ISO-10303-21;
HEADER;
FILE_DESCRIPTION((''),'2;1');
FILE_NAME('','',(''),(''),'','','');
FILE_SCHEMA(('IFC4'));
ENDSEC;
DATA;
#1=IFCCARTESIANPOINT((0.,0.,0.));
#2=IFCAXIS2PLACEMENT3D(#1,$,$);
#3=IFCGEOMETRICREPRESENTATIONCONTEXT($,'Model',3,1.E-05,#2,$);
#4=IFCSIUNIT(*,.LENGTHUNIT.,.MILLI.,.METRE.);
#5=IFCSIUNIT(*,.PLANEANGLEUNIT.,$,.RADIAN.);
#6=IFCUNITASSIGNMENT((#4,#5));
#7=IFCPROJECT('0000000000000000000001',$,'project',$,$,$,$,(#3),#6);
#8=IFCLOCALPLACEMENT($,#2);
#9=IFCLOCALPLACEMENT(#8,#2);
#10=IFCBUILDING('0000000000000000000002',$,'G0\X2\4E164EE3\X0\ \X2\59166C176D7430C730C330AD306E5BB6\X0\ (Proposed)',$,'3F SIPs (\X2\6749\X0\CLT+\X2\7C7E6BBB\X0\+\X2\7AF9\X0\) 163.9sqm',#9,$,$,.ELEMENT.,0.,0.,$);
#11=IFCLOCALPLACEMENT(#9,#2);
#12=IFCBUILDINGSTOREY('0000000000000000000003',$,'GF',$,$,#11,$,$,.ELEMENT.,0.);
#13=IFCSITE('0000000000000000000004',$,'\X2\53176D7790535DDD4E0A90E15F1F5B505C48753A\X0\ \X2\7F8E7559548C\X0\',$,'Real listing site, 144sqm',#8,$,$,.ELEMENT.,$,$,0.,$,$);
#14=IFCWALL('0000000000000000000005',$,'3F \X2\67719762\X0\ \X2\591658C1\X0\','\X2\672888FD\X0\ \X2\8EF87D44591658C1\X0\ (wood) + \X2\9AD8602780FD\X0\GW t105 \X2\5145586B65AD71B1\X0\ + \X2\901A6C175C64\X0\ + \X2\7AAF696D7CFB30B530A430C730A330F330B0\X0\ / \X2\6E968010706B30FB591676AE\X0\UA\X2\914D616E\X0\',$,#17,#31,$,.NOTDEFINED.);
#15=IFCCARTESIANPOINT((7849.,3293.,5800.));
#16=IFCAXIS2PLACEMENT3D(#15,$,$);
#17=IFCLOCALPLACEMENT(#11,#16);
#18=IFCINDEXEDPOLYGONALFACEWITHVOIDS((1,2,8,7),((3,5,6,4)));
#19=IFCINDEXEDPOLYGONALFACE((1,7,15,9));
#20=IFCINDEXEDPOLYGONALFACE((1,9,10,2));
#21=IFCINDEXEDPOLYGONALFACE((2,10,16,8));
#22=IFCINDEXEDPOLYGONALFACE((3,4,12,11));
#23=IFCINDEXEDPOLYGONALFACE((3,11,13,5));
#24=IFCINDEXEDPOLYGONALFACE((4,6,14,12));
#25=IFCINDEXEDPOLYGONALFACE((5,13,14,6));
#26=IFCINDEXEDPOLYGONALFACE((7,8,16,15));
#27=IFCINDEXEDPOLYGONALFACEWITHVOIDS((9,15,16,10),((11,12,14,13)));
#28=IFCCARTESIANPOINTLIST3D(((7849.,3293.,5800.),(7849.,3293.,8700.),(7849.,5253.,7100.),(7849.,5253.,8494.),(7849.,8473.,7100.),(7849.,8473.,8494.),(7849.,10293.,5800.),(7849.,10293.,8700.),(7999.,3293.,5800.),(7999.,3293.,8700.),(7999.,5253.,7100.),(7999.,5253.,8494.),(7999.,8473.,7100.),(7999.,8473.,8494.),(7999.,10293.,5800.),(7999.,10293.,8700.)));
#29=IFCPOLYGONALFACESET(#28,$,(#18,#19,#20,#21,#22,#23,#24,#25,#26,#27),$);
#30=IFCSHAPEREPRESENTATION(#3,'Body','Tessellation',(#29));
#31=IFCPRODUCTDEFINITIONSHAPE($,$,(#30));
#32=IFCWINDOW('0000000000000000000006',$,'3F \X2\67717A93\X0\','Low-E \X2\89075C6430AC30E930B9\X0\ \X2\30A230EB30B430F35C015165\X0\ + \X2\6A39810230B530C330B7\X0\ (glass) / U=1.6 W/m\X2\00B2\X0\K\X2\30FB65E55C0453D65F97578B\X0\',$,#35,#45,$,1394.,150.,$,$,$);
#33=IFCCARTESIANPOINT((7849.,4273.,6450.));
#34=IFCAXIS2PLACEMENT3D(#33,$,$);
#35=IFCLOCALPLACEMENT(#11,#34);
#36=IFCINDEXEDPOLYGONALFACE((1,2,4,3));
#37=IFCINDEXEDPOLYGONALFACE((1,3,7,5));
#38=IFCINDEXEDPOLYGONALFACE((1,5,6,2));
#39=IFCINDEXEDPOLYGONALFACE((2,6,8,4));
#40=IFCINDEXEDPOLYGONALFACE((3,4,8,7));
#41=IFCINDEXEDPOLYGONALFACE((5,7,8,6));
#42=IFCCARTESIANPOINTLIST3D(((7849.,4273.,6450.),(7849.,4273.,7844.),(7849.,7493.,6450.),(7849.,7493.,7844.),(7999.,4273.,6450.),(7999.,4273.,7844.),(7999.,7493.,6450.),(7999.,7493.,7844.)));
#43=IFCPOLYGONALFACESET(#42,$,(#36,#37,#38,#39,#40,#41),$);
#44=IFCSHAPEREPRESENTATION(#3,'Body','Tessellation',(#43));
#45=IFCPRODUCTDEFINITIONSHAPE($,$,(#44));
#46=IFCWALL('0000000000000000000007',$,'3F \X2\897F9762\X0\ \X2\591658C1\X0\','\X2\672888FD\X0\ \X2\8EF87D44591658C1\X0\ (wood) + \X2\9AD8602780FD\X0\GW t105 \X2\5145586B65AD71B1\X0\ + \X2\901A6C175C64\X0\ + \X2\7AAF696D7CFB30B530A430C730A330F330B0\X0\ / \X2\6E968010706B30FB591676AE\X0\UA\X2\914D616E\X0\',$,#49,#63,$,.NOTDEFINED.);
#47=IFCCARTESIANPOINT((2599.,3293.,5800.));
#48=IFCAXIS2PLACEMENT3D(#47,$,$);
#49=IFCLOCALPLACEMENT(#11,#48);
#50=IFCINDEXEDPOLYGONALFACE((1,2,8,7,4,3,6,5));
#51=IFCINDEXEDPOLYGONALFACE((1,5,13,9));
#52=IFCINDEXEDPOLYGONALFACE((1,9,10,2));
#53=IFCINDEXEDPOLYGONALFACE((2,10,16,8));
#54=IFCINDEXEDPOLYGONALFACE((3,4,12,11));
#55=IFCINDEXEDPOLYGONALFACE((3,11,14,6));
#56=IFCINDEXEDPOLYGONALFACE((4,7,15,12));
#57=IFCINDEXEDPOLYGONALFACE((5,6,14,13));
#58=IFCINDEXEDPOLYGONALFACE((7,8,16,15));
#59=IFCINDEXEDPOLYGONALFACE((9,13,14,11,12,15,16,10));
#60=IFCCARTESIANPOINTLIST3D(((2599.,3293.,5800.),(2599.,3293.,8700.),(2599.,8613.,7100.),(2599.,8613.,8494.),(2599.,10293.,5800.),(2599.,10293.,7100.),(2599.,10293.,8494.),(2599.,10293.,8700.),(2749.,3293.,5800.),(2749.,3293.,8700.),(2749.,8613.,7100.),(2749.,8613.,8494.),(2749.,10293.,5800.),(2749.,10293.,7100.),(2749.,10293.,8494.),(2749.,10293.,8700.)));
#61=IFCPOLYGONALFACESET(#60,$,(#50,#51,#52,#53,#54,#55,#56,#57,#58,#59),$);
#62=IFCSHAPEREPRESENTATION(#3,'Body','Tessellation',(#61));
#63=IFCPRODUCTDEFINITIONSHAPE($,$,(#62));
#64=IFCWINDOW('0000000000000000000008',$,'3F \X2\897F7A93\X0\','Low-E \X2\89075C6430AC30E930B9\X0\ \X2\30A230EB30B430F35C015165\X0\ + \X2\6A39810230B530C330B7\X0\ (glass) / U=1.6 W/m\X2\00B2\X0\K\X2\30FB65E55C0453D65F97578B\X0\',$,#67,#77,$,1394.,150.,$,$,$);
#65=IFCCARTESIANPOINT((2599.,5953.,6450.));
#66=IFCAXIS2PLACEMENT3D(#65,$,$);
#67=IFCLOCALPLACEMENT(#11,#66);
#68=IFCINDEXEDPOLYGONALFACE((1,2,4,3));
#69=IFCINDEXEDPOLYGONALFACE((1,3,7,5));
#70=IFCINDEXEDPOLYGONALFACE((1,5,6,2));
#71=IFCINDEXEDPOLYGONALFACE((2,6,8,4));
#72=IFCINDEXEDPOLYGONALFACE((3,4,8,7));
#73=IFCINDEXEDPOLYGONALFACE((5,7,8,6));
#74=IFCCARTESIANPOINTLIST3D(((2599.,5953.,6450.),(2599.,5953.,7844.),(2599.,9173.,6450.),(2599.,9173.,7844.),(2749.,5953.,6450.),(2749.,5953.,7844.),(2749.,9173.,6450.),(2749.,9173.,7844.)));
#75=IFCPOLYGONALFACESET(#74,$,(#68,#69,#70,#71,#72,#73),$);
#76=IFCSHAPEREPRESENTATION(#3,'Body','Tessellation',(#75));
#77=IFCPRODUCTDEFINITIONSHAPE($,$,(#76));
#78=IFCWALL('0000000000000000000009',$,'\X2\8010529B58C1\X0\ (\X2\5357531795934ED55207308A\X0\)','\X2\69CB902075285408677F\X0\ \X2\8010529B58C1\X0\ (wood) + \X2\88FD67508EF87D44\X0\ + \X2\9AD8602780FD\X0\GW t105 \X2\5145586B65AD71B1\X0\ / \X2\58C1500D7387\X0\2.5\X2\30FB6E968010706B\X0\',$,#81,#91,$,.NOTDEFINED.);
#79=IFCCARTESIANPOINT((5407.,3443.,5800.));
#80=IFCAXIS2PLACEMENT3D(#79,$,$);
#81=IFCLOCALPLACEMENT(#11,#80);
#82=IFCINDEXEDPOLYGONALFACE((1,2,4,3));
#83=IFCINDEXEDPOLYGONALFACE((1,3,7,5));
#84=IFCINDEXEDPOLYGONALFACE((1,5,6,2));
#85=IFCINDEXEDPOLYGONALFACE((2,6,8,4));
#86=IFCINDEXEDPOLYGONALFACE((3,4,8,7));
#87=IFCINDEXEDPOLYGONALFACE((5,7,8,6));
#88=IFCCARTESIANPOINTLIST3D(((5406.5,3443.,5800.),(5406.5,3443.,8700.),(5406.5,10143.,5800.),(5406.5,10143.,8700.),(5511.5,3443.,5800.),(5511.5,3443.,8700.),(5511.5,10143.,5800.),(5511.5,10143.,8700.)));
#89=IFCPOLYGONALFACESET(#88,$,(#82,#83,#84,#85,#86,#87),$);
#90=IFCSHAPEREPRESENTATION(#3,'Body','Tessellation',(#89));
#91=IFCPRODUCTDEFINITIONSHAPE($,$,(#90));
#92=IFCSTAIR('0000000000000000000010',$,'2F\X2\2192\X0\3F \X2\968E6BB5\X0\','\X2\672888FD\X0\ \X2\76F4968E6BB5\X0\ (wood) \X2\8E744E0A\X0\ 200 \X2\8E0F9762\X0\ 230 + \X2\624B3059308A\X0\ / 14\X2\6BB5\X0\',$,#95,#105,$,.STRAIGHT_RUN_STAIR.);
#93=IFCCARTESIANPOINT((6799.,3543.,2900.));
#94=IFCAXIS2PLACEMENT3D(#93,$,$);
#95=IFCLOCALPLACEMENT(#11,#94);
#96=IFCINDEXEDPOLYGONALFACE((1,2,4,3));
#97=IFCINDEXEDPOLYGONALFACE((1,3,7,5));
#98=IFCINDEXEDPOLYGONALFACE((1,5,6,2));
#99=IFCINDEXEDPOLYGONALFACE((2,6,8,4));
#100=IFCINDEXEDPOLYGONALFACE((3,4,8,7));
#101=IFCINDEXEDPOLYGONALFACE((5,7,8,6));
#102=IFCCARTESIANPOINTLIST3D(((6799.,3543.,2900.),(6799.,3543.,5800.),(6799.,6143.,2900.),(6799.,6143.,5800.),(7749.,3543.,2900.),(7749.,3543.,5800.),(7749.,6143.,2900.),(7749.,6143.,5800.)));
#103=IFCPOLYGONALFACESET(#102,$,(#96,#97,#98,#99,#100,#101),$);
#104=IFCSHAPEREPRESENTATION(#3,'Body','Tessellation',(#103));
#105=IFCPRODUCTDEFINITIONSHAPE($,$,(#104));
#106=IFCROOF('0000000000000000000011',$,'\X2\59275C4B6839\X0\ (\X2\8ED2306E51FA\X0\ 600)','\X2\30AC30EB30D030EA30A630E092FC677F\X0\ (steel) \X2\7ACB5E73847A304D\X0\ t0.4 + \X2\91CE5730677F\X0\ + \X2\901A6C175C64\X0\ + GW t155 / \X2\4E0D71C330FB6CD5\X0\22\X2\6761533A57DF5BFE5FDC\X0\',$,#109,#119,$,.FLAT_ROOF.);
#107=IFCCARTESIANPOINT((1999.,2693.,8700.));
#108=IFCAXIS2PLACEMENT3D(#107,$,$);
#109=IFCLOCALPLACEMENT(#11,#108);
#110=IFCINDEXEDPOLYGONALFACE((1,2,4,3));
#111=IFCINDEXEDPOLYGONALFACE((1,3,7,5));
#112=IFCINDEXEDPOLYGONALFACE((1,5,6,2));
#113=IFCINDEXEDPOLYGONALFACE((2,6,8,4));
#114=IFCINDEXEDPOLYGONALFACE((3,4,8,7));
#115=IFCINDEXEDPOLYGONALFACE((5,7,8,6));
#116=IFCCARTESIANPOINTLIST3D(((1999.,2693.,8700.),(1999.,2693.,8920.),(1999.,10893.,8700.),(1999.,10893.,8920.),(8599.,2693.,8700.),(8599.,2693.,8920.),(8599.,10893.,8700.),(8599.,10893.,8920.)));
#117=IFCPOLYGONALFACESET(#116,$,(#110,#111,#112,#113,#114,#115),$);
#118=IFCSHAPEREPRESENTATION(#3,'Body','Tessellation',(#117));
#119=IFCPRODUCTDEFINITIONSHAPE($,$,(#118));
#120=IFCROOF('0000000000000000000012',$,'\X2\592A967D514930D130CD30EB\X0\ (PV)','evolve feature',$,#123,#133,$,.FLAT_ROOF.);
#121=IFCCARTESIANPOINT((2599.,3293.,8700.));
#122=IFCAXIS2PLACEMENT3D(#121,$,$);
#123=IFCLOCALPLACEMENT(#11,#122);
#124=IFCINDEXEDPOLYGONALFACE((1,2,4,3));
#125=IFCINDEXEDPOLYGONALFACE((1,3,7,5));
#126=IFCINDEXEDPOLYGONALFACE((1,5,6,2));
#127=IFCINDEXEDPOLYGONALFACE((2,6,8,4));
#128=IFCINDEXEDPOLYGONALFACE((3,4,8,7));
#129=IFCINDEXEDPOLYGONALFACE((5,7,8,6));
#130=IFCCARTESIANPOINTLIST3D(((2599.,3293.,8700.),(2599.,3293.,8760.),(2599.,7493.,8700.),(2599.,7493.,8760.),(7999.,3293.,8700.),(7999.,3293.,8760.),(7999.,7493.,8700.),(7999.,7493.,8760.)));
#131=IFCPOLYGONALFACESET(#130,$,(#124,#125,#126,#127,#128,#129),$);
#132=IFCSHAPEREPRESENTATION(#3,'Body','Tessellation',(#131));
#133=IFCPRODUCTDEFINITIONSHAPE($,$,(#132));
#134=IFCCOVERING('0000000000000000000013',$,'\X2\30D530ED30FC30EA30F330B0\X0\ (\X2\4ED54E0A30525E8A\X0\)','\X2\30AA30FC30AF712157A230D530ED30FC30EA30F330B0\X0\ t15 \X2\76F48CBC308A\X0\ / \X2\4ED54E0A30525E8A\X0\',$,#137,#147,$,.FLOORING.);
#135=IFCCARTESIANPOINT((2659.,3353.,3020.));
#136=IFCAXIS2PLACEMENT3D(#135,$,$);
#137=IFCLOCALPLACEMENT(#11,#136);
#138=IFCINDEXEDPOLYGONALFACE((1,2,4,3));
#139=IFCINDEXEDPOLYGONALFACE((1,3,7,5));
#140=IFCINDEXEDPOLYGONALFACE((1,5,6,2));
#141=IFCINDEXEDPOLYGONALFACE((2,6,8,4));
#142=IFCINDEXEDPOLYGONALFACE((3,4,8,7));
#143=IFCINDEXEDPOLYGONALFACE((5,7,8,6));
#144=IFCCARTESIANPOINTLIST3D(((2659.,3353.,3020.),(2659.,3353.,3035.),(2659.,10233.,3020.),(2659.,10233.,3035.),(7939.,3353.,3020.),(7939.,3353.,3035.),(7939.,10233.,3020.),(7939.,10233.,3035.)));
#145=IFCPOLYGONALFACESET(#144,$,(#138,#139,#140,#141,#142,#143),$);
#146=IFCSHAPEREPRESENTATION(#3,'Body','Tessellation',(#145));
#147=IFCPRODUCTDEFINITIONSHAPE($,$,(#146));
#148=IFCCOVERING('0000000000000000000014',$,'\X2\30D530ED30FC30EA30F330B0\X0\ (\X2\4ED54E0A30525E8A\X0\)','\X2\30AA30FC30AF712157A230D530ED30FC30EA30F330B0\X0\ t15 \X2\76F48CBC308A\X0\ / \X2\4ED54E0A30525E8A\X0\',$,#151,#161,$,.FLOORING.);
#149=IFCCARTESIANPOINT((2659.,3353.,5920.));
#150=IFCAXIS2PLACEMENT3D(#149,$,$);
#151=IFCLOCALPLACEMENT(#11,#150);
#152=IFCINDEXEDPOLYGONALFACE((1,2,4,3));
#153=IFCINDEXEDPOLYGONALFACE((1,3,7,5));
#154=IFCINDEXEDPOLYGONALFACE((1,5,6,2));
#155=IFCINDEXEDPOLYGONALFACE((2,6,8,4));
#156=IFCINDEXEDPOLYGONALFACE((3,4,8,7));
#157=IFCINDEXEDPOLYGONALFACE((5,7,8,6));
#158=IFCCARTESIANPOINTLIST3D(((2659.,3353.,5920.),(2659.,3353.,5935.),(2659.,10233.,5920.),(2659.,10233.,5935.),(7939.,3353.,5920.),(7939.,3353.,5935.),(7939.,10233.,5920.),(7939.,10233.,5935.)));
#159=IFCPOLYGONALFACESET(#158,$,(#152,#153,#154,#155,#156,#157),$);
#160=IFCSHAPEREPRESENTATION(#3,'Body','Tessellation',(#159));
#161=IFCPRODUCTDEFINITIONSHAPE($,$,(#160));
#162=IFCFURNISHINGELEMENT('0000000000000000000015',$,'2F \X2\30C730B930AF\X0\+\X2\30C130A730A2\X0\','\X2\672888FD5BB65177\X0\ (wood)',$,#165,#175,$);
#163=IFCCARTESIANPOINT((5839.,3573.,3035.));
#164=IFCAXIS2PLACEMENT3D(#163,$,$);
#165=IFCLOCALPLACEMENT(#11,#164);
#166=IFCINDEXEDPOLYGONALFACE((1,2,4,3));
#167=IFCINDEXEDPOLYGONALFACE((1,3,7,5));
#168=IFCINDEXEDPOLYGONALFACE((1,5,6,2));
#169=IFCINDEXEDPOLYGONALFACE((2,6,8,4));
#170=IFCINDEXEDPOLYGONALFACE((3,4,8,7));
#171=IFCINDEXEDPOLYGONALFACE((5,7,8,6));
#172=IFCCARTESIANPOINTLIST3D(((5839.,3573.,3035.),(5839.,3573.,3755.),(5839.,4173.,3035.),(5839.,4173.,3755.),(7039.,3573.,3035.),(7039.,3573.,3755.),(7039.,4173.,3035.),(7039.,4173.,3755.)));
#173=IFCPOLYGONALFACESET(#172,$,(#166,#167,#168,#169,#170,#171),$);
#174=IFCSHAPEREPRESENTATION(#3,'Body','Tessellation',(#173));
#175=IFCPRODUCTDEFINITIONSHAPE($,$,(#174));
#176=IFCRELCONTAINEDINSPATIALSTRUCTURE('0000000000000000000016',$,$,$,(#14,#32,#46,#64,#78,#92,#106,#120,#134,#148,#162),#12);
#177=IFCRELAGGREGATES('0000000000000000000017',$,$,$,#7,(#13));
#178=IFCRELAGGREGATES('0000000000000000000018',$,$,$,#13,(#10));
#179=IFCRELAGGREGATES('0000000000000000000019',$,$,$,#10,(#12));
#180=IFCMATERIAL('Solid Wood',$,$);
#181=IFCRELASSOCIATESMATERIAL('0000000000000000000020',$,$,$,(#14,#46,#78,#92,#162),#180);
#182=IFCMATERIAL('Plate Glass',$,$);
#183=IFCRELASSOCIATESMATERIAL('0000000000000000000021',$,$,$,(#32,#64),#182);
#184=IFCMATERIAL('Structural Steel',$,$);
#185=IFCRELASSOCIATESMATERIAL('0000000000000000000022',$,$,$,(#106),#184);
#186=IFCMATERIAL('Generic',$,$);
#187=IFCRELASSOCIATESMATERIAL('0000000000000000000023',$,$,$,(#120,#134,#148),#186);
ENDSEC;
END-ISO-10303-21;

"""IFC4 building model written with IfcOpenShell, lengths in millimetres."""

from ifc_helpers import new_model, si_unit, frame, frame_2d, origin, place, context, project, spatial, rectangle, extrude, material, element, fill, save


model = new_model("IFC4")

# Units and contexts
model_context = context("Model", 3, precision=1e-05, world=origin())
ifc_project = project(units=[si_unit("LENGTHUNIT", "METRE", prefix="MILLI"), si_unit("PLANEANGLEUNIT", "RADIAN")], contexts=[model_context])

# Site, building, storey
site_placement = place(None, origin())
site = spatial("IfcSite", under=ifc_project, at=site_placement, Name="北海道川上郡弟子屈町 美留和", ObjectType="Real listing site, 144sqm", CompositionType="ELEMENT", RefElevation=0.0)
building_placement = place(site_placement, origin())
building = spatial("IfcBuilding", under=site, at=building_placement, Name="G0世代 外気浴デッキの家 (Proposed)", ObjectType="3F SIPs (杉CLT+籾殻+竹) 163.9sqm", CompositionType="ELEMENT", ElevationOfRefHeight=0.0, ElevationOfTerrain=0.0)
storey_placement = place(building_placement, origin())
storey = spatial("IfcBuildingStorey", under=building, at=storey_placement, Name="GF", CompositionType="ELEMENT", Elevation=0.0)

# Shared definitions
ifc_material_1 = material(Name="Solid Wood")

# Shared definitions
ifc_material_2 = material(Name="Plate Glass")

# Shared definitions
ifc_material_3 = material(Name="Generic")

# Walls, openings, windows
wall_1_placement = place(storey_placement, frame((7849.0, 3293.0, 5800.0)))
wall_1 = element("IfcWall", 1, at=wall_1_placement, inside=storey, material=ifc_material_1, Name="3F 東面 外壁", Description="木製 軸組外壁 (wood) + 高性能GW t105 充填断熱 + 通気層 + 窯業系サイディング / 準耐火・外皮UA配慮", PredefinedType="NOTDEFINED", context=model_context, shape_type="SweptSolid", body=[
    extrude(rectangle(XDim=150.0, YDim=7000.0, at=frame_2d((75.0, 3500.0))), frame((7849.0, 3293.0, 5800.0)), (0.0, 0.0, 1.0), 2900.0),
])
opening_1_placement = place(storey_placement, frame((7849.0, 4273.0, 6450.0)))
opening_1 = element("IfcOpeningElement", 2, at=opening_1_placement, cuts=wall_1, PredefinedType="NOTDEFINED", context=model_context, shape_type="SweptSolid", body=[
    extrude(rectangle(XDim=150.0, YDim=3220.0, at=frame_2d((75.0, 1610.0))), frame((7849.0, 4273.0, 6450.0)), (0.0, 0.0, 1.0), 1394.0),
])
window_1_placement = place(storey_placement, frame((7849.0, 4273.0, 6450.0)))
window_1 = element("IfcWindow", 3, at=window_1_placement, inside=storey, material=ifc_material_2, Name="3F 東窓", Description="Low-E 複層ガラス アルゴン封入 + 樹脂サッシ (glass) / U=1.6 W/m²K・日射取得型", OverallHeight=1394.0, OverallWidth=150.0, context=model_context, shape_type="SweptSolid", body=[
    extrude(rectangle(XDim=150.0, YDim=3220.0, at=frame_2d((75.0, 1610.0))), frame((7849.0, 4273.0, 6450.0)), (0.0, 0.0, 1.0), 1394.0),
])
fill(opening_1, window_1)
wall_2_placement = place(storey_placement, frame((2599.0, 3293.0, 5800.0)))
wall_2 = element("IfcWall", 4, at=wall_2_placement, inside=storey, material=ifc_material_1, Name="3F 西面 外壁", Description="木製 軸組外壁 (wood) + 高性能GW t105 充填断熱 + 通気層 + 窯業系サイディング / 準耐火・外皮UA配慮", PredefinedType="NOTDEFINED", context=model_context, shape_type="SweptSolid", body=[
    extrude(rectangle(XDim=150.0, YDim=7000.0, at=frame_2d((75.0, 3500.0))), frame((2599.0, 3293.0, 5800.0)), (0.0, 0.0, 1.0), 2900.0),
])
opening_2_placement = place(storey_placement, frame((2599.0, 5953.0, 6450.0)))
opening_2 = element("IfcOpeningElement", 5, at=opening_2_placement, cuts=wall_2, PredefinedType="NOTDEFINED", context=model_context, shape_type="SweptSolid", body=[
    extrude(rectangle(XDim=150.0, YDim=3220.0, at=frame_2d((75.0, 1610.0))), frame((2599.0, 5953.0, 6450.0)), (0.0, 0.0, 1.0), 1394.0),
])
window_2_placement = place(storey_placement, frame((2599.0, 5953.0, 6450.0)))
window_2 = element("IfcWindow", 6, at=window_2_placement, inside=storey, material=ifc_material_2, Name="3F 西窓", Description="Low-E 複層ガラス アルゴン封入 + 樹脂サッシ (glass) / U=1.6 W/m²K・日射取得型", OverallHeight=1394.0, OverallWidth=150.0, context=model_context, shape_type="SweptSolid", body=[
    extrude(rectangle(XDim=150.0, YDim=3220.0, at=frame_2d((75.0, 1610.0))), frame((2599.0, 5953.0, 6450.0)), (0.0, 0.0, 1.0), 1394.0),
])
fill(opening_2, window_2)

# Wall
wall_3_placement = place(storey_placement, frame((5407.0, 3443.0, 5800.0)))
element("IfcWall", 7, at=wall_3_placement, inside=storey, material=ifc_material_1, Name="耐力壁 (南北間仕切り)", Description="構造用合板 耐力壁 (wood) + 製材軸組 + 高性能GW t105 充填断熱 / 壁倍率2.5・準耐火", PredefinedType="NOTDEFINED", context=model_context, shape_type="SweptSolid", body=[
    extrude(rectangle(XDim=105.0, YDim=6700.0, at=frame_2d((52.0, 3350.0))), frame((5407.0, 3443.0, 5800.0)), (0.0, 0.0, 1.0), 2900.0),
])

# Stair
stair_placement = place(storey_placement, frame((6799.0, 3543.0, 2900.0)))
element("IfcStair", 8, at=stair_placement, inside=storey, material=ifc_material_1, Name="2F→3F 階段", Description="木製 直階段 (wood) 蹴上 200 踏面 230 + 手すり / 14段", PredefinedType="STRAIGHT_RUN_STAIR", context=model_context, shape_type="SweptSolid", body=[
    extrude(rectangle(XDim=950.0, YDim=2600.0, at=frame_2d((475.0, 1300.0))), frame((6799.0, 3543.0, 2900.0)), (0.0, 0.0, 1.0), 2900.0),
])

# Roofs
ifc_material_4 = material(Name="Structural Steel")
roof_1_placement = place(storey_placement, frame((1999.0, 2693.0, 8700.0)))
element("IfcRoof", 9, at=roof_1_placement, inside=storey, material=ifc_material_4, Name="大屋根 (軒の出 600)", Description="ガルバリウム鋼板 (steel) 立平葺き t0.4 + 野地板 + 通気層 + GW t155 / 不燃・法22条区域対応", PredefinedType="FLAT_ROOF", context=model_context, shape_type="SweptSolid", body=[
    extrude(rectangle(XDim=6600.0, YDim=8200.0, at=frame_2d((3300.0, 4100.0))), frame((1999.0, 2693.0, 8700.0)), (0.0, 0.0, 1.0), 220.0),
])
roof_2_placement = place(storey_placement, frame((2599.0, 3293.0, 8700.0)))
element("IfcRoof", 10, at=roof_2_placement, inside=storey, material=ifc_material_3, Name="太陽光パネル (PV)", Description="evolve feature", PredefinedType="FLAT_ROOF", context=model_context, shape_type="SweptSolid", body=[
    extrude(rectangle(XDim=5400.0, YDim=4200.0, at=frame_2d((2700.0, 2100.0))), frame((2599.0, 3293.0, 8700.0)), (0.0, 0.0, 1.0), 60.0),
])

# Coverings
covering_1_placement = place(storey_placement, frame((2659.0, 3353.0, 3020.0)))
element("IfcCovering", 11, at=covering_1_placement, inside=storey, material=ifc_material_3, Name="フローリング (仕上げ床)", Description="オーク無垢フローリング t15 直貼り / 仕上げ床", PredefinedType="FLOORING", context=model_context, shape_type="SweptSolid", body=[
    extrude(rectangle(XDim=5280.0, YDim=6880.0, at=frame_2d((2640.0, 3440.0))), frame((2659.0, 3353.0, 3020.0)), (0.0, 0.0, 1.0), 15.0),
])
covering_2_placement = place(storey_placement, frame((2659.0, 3353.0, 5920.0)))
element("IfcCovering", 12, at=covering_2_placement, inside=storey, material=ifc_material_3, Name="フローリング (仕上げ床)", Description="オーク無垢フローリング t15 直貼り / 仕上げ床", PredefinedType="FLOORING", context=model_context, shape_type="SweptSolid", body=[
    extrude(rectangle(XDim=5280.0, YDim=6880.0, at=frame_2d((2640.0, 3440.0))), frame((2659.0, 3353.0, 5920.0)), (0.0, 0.0, 1.0), 15.0),
])

# Furnishing element
furnishing_placement = place(storey_placement, frame((5839.0, 3573.0, 3035.0)))
element("IfcFurnishingElement", 13, at=furnishing_placement, inside=storey, material=ifc_material_1, Name="2F デスク+チェア", Description="木製家具 (wood)", context=model_context, shape_type="SweptSolid", body=[
    extrude(rectangle(XDim=1200.0, YDim=600.0, at=frame_2d((600.0, 300.0))), frame((5839.0, 3573.0, 3035.0)), (0.0, 0.0, 1.0), 720.0),
])

save(model, "model.ifc")
